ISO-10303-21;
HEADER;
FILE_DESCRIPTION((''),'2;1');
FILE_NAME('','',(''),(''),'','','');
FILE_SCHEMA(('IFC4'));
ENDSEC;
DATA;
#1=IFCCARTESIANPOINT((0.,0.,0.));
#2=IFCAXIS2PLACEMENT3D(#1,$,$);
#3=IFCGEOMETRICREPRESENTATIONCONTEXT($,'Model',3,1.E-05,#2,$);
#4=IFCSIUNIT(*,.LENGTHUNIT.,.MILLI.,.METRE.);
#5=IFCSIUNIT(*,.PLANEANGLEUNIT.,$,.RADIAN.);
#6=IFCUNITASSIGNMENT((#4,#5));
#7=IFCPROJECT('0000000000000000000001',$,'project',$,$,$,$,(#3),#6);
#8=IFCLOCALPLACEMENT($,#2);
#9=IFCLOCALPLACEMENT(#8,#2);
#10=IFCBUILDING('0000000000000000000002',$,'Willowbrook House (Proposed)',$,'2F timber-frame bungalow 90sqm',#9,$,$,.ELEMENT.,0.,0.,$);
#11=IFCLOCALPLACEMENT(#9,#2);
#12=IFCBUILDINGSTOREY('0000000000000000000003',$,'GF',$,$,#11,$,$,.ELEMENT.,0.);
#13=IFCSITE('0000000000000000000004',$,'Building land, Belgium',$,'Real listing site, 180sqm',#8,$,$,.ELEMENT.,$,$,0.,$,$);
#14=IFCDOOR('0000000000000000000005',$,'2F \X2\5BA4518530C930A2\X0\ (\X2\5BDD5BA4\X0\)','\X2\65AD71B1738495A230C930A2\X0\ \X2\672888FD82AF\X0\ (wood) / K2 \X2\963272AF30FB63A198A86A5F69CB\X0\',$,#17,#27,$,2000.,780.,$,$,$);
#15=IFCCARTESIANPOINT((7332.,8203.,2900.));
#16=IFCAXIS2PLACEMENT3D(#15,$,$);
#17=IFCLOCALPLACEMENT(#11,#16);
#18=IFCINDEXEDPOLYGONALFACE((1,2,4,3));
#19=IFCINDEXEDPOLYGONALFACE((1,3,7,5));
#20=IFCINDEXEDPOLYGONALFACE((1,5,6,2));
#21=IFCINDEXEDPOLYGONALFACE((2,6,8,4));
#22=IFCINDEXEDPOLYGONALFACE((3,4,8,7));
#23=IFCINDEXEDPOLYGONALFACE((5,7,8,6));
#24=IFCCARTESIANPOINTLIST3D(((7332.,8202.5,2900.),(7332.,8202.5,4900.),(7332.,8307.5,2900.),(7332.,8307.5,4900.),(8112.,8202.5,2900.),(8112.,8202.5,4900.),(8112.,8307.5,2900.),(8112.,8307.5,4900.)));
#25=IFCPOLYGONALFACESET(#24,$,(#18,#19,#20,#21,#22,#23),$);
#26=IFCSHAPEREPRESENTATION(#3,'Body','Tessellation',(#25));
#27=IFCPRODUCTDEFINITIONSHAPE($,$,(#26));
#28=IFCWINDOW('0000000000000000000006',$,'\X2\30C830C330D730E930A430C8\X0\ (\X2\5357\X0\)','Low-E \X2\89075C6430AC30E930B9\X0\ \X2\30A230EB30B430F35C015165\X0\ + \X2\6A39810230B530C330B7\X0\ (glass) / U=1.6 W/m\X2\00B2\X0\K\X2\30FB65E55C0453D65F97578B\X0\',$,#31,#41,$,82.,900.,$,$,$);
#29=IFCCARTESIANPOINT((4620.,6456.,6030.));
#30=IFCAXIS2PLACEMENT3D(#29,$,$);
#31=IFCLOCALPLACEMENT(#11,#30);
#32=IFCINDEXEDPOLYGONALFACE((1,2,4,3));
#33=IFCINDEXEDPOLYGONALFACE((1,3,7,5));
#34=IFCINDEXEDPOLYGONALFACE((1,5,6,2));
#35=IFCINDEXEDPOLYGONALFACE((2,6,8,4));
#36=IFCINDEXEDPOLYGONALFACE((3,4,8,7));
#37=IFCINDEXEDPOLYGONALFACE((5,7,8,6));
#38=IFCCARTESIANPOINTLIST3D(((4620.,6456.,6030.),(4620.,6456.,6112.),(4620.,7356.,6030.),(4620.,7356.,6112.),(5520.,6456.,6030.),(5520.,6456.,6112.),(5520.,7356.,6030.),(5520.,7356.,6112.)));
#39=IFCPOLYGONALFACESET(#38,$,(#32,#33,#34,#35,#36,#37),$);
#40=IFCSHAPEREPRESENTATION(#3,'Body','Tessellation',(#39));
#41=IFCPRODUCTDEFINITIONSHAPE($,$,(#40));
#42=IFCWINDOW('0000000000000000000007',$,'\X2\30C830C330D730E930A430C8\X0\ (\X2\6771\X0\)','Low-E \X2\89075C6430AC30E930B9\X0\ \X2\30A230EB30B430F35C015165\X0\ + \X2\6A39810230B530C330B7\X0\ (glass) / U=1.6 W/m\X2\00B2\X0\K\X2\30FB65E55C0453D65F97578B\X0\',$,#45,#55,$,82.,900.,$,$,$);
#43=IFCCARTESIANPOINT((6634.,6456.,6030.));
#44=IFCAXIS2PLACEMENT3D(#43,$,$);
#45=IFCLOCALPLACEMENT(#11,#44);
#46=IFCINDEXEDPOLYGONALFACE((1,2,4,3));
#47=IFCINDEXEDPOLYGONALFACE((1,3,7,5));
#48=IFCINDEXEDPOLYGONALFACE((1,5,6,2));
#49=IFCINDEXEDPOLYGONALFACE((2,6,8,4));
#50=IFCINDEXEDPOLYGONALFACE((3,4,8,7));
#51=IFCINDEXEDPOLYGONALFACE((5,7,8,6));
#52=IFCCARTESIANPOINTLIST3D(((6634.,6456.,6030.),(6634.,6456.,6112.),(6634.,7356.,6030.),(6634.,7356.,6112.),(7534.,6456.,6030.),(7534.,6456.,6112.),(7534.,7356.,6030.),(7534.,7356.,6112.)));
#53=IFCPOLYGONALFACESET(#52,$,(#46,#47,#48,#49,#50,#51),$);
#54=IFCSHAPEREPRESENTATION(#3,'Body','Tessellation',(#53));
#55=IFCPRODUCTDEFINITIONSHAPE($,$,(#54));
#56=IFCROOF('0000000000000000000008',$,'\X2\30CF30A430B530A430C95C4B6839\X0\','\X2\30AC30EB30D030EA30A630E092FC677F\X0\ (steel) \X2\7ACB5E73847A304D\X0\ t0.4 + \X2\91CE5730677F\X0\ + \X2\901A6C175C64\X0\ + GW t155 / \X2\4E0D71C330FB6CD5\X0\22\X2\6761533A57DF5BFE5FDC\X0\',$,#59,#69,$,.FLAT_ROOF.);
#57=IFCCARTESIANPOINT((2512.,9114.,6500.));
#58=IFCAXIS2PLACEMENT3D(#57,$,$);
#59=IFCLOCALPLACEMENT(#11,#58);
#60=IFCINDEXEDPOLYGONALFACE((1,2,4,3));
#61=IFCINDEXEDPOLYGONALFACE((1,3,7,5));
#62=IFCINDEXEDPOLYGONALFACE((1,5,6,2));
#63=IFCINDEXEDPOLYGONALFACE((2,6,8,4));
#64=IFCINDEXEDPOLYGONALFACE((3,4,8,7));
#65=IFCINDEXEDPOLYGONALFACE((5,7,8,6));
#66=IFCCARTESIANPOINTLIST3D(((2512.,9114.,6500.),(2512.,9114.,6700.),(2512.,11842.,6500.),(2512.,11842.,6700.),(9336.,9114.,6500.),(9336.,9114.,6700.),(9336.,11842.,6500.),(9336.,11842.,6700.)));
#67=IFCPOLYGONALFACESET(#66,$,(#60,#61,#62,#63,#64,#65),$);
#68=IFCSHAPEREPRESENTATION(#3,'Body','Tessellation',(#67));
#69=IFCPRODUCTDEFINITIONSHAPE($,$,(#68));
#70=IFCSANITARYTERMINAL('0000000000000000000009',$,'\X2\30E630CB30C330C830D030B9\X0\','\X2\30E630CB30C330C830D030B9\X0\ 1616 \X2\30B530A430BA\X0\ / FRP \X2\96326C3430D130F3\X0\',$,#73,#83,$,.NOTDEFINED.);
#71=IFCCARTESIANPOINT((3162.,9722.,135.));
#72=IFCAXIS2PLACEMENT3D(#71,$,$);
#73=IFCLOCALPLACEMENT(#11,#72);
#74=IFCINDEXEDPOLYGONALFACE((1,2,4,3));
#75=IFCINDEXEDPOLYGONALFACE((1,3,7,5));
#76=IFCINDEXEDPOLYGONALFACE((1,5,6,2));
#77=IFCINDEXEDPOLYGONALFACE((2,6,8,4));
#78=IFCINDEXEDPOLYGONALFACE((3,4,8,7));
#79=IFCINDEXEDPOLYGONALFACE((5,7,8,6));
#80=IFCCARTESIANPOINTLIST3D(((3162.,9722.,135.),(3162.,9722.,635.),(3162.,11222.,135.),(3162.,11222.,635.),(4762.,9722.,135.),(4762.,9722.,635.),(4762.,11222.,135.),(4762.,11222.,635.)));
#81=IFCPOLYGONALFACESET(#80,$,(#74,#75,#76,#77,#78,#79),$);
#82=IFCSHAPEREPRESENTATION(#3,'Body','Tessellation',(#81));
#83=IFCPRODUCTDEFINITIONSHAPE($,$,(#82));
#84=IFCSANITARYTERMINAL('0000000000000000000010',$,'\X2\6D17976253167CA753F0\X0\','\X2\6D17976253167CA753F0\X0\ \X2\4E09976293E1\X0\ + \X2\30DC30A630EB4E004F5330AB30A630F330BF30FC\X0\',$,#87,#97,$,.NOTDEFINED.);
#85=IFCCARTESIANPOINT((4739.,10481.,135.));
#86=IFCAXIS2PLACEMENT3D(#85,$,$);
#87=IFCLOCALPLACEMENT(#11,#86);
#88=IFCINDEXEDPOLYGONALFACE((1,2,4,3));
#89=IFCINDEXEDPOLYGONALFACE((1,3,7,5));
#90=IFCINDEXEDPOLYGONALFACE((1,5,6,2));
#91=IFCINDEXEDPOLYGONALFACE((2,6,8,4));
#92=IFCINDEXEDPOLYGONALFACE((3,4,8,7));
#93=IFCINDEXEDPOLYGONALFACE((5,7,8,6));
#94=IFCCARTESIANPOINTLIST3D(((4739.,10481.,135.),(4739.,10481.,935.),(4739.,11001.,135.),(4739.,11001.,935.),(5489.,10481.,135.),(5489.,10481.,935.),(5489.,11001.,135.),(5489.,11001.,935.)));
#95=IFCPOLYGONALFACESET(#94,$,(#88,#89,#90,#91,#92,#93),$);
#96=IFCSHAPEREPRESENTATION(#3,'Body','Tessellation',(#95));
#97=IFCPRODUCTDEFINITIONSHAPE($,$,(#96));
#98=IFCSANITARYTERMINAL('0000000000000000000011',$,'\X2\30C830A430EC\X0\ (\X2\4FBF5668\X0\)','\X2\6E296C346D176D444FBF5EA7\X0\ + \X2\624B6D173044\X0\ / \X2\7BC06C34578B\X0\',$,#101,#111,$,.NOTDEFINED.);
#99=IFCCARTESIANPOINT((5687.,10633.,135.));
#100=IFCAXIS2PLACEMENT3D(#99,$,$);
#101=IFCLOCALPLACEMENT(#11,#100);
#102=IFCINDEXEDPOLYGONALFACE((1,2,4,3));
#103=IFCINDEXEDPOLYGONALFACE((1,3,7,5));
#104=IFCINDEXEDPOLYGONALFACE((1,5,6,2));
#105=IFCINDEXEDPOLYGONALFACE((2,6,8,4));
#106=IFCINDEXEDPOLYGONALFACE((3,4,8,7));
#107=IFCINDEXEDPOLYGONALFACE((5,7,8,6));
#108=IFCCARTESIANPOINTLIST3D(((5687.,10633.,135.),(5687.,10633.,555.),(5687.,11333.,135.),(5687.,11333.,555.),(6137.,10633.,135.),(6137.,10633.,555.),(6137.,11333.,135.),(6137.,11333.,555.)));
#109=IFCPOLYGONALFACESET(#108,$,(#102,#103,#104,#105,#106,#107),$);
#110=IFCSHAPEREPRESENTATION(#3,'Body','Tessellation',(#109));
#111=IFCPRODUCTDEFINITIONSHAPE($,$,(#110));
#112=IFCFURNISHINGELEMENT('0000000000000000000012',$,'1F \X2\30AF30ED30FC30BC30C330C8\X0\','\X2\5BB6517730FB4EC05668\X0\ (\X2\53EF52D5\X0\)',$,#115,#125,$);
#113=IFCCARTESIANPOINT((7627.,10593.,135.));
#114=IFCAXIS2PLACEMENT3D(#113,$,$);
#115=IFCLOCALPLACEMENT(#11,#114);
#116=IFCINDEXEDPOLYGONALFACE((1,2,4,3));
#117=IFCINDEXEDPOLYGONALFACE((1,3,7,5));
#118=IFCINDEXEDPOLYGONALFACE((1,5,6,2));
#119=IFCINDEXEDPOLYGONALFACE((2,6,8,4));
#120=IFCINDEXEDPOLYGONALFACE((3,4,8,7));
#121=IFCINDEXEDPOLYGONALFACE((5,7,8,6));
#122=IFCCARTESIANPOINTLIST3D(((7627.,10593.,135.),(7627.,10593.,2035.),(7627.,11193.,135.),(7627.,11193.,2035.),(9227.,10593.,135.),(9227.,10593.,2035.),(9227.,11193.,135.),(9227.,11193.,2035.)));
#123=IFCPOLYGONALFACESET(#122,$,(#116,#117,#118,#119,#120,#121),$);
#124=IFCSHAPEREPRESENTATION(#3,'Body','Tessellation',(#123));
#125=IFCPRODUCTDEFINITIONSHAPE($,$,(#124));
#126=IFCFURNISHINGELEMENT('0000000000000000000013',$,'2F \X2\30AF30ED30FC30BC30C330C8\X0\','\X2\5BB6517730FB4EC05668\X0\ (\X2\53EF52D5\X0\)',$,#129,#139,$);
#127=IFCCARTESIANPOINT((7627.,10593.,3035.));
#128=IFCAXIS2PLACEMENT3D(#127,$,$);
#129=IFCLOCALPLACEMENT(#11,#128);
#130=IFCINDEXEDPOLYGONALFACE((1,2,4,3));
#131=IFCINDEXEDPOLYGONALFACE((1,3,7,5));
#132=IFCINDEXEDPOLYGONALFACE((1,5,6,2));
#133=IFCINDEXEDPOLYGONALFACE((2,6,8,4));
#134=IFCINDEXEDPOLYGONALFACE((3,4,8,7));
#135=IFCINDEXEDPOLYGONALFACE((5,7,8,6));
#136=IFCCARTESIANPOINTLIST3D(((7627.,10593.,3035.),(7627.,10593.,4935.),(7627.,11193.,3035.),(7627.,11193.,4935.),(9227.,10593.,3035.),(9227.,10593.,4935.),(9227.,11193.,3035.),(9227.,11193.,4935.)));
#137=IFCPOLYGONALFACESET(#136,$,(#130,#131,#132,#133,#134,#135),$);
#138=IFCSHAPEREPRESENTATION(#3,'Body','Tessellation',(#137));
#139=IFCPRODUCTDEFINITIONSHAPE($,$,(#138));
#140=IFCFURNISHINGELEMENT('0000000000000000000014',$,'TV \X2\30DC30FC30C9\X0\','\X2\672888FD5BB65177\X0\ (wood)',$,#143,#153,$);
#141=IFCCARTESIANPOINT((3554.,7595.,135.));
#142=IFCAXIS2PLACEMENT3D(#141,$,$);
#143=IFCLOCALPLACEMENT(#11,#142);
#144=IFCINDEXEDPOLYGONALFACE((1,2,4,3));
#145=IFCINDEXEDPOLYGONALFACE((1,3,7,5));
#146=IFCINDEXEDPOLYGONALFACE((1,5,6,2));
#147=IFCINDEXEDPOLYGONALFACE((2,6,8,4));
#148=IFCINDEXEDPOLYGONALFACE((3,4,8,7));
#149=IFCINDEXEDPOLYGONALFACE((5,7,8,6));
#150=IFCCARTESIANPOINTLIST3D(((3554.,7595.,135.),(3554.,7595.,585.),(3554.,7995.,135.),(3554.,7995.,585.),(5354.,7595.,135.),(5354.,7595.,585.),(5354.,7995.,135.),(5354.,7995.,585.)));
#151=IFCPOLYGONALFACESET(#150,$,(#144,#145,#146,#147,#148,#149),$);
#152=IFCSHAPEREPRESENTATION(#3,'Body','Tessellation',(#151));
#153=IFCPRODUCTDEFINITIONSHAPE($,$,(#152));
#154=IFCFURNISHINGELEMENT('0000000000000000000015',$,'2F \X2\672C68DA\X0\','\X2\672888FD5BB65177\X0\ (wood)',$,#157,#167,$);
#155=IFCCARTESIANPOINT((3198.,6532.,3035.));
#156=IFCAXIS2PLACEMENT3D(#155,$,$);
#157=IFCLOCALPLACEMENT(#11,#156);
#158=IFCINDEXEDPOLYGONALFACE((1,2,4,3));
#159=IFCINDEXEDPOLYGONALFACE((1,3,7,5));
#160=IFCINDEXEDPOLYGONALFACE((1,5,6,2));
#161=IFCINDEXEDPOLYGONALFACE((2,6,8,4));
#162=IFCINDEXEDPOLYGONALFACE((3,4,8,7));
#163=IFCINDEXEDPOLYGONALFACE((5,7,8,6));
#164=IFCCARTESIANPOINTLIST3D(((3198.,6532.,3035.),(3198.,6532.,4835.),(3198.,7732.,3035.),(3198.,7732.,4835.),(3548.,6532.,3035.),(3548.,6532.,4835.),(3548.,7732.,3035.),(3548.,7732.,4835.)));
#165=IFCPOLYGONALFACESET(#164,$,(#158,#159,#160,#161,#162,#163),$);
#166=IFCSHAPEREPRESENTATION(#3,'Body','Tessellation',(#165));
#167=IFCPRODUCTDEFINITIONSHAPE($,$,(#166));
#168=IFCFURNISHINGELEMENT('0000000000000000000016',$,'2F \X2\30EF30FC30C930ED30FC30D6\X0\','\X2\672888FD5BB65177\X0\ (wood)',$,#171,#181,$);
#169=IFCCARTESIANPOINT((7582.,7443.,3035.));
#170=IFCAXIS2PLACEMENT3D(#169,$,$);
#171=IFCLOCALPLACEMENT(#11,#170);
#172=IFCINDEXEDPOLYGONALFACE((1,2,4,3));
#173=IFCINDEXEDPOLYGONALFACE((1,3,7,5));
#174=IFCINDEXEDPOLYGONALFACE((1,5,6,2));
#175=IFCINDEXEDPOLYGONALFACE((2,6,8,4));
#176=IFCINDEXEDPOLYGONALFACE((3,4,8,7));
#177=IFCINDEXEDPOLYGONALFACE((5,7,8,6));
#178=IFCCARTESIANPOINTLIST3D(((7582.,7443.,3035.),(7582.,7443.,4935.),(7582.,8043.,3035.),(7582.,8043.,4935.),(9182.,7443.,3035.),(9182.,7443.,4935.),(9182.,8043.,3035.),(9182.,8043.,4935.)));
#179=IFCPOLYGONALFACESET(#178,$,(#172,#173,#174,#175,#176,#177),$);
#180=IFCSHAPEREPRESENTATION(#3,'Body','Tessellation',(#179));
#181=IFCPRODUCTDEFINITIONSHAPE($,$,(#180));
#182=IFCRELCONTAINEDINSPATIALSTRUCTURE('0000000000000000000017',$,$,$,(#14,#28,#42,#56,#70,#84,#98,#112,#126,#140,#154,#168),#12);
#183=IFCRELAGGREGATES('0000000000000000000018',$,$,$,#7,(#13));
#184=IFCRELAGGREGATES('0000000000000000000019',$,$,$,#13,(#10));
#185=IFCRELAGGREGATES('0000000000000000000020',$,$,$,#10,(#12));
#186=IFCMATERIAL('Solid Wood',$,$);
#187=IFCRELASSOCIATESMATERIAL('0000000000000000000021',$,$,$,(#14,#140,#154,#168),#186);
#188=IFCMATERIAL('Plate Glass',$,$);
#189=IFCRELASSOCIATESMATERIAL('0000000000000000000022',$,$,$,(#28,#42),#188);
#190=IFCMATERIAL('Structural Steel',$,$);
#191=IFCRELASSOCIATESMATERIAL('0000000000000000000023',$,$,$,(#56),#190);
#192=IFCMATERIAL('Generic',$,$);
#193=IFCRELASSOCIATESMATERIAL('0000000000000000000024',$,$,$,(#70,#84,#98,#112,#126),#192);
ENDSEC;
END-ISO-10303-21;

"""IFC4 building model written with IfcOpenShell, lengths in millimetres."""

from ifc_helpers import new_model, si_unit, frame, frame_2d, origin, place, context, project, spatial, rectangle, extrude, material, element, save


model = new_model("IFC4")

# Units and contexts
model_context = context("Model", 3, precision=1e-05, world=origin())
ifc_project = project(units=[si_unit("LENGTHUNIT", "METRE", prefix="MILLI"), si_unit("PLANEANGLEUNIT", "RADIAN")], contexts=[model_context])

# Site, building, storey
site_placement = place(None, origin())
site = spatial("IfcSite", under=ifc_project, at=site_placement, Name="Building land, Belgium", ObjectType="Real listing site, 180sqm", CompositionType="ELEMENT", RefElevation=0.0)
building_placement = place(site_placement, origin())
building = spatial("IfcBuilding", under=site, at=building_placement, Name="Willowbrook House (Proposed)", ObjectType="2F timber-frame bungalow 90sqm", CompositionType="ELEMENT", ElevationOfRefHeight=0.0, ElevationOfTerrain=0.0)
storey_placement = place(building_placement, origin())
storey = spatial("IfcBuildingStorey", under=building, at=storey_placement, Name="GF", CompositionType="ELEMENT", Elevation=0.0)

# Shared definitions
ifc_material_1 = material(Name="Solid Wood")
ifc_material_2 = material(Name="Plate Glass")

# Door
door_1_placement = place(storey_placement, frame((7332.0, 8203.0, 2900.0)))
element("IfcDoor", 1, at=door_1_placement, inside=storey, material=ifc_material_1, Name="2F 室内ドア (寝室)", Description="断熱玄関ドア 木製芯 (wood) / K2 防犯・採風機構", OverallHeight=2000.0, OverallWidth=780.0, context=model_context, shape_type="SweptSolid", body=[
    extrude(rectangle(XDim=780.0, YDim=105.0, at=frame_2d((390.0, 52.0))), frame((7332.0, 8203.0, 2900.0)), (0.0, 0.0, 1.0), 2000.0),
])

# Windows
window_1_placement = place(storey_placement, frame((4620.0, 6456.0, 6030.0)))
element("IfcWindow", 2, at=window_1_placement, inside=storey, material=ifc_material_2, Name="トップライト (南)", Description="Low-E 複層ガラス アルゴン封入 + 樹脂サッシ (glass) / U=1.6 W/m²K・日射取得型", OverallHeight=82.0, OverallWidth=900.0, context=model_context, shape_type="SweptSolid", body=[
    extrude(rectangle(XDim=900.0, YDim=900.0, at=frame_2d((450.0, 450.0))), frame((4620.0, 6456.0, 6030.0)), (0.0, 0.0, 1.0), 82.0),
])
window_2_placement = place(storey_placement, frame((6634.0, 6456.0, 6030.0)))
element("IfcWindow", 3, at=window_2_placement, inside=storey, material=ifc_material_2, Name="トップライト (東)", Description="Low-E 複層ガラス アルゴン封入 + 樹脂サッシ (glass) / U=1.6 W/m²K・日射取得型", OverallHeight=82.0, OverallWidth=900.0, context=model_context, shape_type="SweptSolid", body=[
    extrude(rectangle(XDim=900.0, YDim=900.0, at=frame_2d((450.0, 450.0))), frame((6634.0, 6456.0, 6030.0)), (0.0, 0.0, 1.0), 82.0),
])

# Roof
ifc_material_3 = material(Name="Structural Steel")
roof_placement = place(storey_placement, frame((2512.0, 9114.0, 6500.0)))
element("IfcRoof", 4, at=roof_placement, inside=storey, material=ifc_material_3, Name="ハイサイド屋根", Description="ガルバリウム鋼板 (steel) 立平葺き t0.4 + 野地板 + 通気層 + GW t155 / 不燃・法22条区域対応", PredefinedType="FLAT_ROOF", context=model_context, shape_type="SweptSolid", body=[
    extrude(rectangle(XDim=6824.0, YDim=2728.0, at=frame_2d((3412.0, 1364.0))), frame((2512.0, 9114.0, 6500.0)), (0.0, 0.0, 1.0), 200.0),
])

# Sanitary terminals
ifc_material_4 = material(Name="Generic")
sanitary_terminal_1_placement = place(storey_placement, frame((3162.0, 9722.0, 135.0)))
element("IfcSanitaryTerminal", 5, at=sanitary_terminal_1_placement, inside=storey, material=ifc_material_4, Name="ユニットバス", Description="ユニットバス 1616 サイズ / FRP 防水パン", PredefinedType="NOTDEFINED", context=model_context, shape_type="SweptSolid", body=[
    extrude(rectangle(XDim=1600.0, YDim=1500.0, at=frame_2d((800.0, 750.0))), frame((3162.0, 9722.0, 135.0)), (0.0, 0.0, 1.0), 500.0),
])
sanitary_terminal_2_placement = place(storey_placement, frame((4739.0, 10481.0, 135.0)))
element("IfcSanitaryTerminal", 6, at=sanitary_terminal_2_placement, inside=storey, material=ifc_material_4, Name="洗面化粧台", Description="洗面化粧台 三面鏡 + ボウル一体カウンター", PredefinedType="NOTDEFINED", context=model_context, shape_type="SweptSolid", body=[
    extrude(rectangle(XDim=750.0, YDim=520.0, at=frame_2d((375.0, 260.0))), frame((4739.0, 10481.0, 135.0)), (0.0, 0.0, 1.0), 800.0),
])
sanitary_terminal_3_placement = place(storey_placement, frame((5687.0, 10633.0, 135.0)))
element("IfcSanitaryTerminal", 7, at=sanitary_terminal_3_placement, inside=storey, material=ifc_material_4, Name="トイレ (便器)", Description="温水洗浄便座 + 手洗い / 節水型", PredefinedType="NOTDEFINED", context=model_context, shape_type="SweptSolid", body=[
    extrude(rectangle(XDim=450.0, YDim=700.0, at=frame_2d((225.0, 350.0))), frame((5687.0, 10633.0, 135.0)), (0.0, 0.0, 1.0), 420.0),
])

# Furnishing elements
furnishing_1_placement = place(storey_placement, frame((7627.0, 10593.0, 135.0)))
element("IfcFurnishingElement", 8, at=furnishing_1_placement, inside=storey, material=ifc_material_4, Name="1F クローゼット", Description="家具・什器 (可動)", context=model_context, shape_type="SweptSolid", body=[
    extrude(rectangle(XDim=1600.0, YDim=600.0, at=frame_2d((800.0, 300.0))), frame((7627.0, 10593.0, 135.0)), (0.0, 0.0, 1.0), 1900.0),
])
furnishing_2_placement = place(storey_placement, frame((7627.0, 10593.0, 3035.0)))
element("IfcFurnishingElement", 9, at=furnishing_2_placement, inside=storey, material=ifc_material_4, Name="2F クローゼット", Description="家具・什器 (可動)", context=model_context, shape_type="SweptSolid", body=[
    extrude(rectangle(XDim=1600.0, YDim=600.0, at=frame_2d((800.0, 300.0))), frame((7627.0, 10593.0, 3035.0)), (0.0, 0.0, 1.0), 1900.0),
])
furnishing_3_placement = place(storey_placement, frame((3554.0, 7595.0, 135.0)))
element("IfcFurnishingElement", 10, at=furnishing_3_placement, inside=storey, material=ifc_material_1, Name="TV ボード", Description="木製家具 (wood)", context=model_context, shape_type="SweptSolid", body=[
    extrude(rectangle(XDim=1800.0, YDim=400.0, at=frame_2d((900.0, 200.0))), frame((3554.0, 7595.0, 135.0)), (0.0, 0.0, 1.0), 450.0),
])
furnishing_4_placement = place(storey_placement, frame((3198.0, 6532.0, 3035.0)))
element("IfcFurnishingElement", 11, at=furnishing_4_placement, inside=storey, material=ifc_material_1, Name="2F 本棚", Description="木製家具 (wood)", context=model_context, shape_type="SweptSolid", body=[
    extrude(rectangle(XDim=350.0, YDim=1200.0, at=frame_2d((175.0, 600.0))), frame((3198.0, 6532.0, 3035.0)), (0.0, 0.0, 1.0), 1800.0),
])
furnishing_5_placement = place(storey_placement, frame((7582.0, 7443.0, 3035.0)))
element("IfcFurnishingElement", 12, at=furnishing_5_placement, inside=storey, material=ifc_material_1, Name="2F ワードローブ", Description="木製家具 (wood)", context=model_context, shape_type="SweptSolid", body=[
    extrude(rectangle(XDim=1600.0, YDim=600.0, at=frame_2d((800.0, 300.0))), frame((7582.0, 7443.0, 3035.0)), (0.0, 0.0, 1.0), 1900.0),
])

save(model, "model.ifc")
